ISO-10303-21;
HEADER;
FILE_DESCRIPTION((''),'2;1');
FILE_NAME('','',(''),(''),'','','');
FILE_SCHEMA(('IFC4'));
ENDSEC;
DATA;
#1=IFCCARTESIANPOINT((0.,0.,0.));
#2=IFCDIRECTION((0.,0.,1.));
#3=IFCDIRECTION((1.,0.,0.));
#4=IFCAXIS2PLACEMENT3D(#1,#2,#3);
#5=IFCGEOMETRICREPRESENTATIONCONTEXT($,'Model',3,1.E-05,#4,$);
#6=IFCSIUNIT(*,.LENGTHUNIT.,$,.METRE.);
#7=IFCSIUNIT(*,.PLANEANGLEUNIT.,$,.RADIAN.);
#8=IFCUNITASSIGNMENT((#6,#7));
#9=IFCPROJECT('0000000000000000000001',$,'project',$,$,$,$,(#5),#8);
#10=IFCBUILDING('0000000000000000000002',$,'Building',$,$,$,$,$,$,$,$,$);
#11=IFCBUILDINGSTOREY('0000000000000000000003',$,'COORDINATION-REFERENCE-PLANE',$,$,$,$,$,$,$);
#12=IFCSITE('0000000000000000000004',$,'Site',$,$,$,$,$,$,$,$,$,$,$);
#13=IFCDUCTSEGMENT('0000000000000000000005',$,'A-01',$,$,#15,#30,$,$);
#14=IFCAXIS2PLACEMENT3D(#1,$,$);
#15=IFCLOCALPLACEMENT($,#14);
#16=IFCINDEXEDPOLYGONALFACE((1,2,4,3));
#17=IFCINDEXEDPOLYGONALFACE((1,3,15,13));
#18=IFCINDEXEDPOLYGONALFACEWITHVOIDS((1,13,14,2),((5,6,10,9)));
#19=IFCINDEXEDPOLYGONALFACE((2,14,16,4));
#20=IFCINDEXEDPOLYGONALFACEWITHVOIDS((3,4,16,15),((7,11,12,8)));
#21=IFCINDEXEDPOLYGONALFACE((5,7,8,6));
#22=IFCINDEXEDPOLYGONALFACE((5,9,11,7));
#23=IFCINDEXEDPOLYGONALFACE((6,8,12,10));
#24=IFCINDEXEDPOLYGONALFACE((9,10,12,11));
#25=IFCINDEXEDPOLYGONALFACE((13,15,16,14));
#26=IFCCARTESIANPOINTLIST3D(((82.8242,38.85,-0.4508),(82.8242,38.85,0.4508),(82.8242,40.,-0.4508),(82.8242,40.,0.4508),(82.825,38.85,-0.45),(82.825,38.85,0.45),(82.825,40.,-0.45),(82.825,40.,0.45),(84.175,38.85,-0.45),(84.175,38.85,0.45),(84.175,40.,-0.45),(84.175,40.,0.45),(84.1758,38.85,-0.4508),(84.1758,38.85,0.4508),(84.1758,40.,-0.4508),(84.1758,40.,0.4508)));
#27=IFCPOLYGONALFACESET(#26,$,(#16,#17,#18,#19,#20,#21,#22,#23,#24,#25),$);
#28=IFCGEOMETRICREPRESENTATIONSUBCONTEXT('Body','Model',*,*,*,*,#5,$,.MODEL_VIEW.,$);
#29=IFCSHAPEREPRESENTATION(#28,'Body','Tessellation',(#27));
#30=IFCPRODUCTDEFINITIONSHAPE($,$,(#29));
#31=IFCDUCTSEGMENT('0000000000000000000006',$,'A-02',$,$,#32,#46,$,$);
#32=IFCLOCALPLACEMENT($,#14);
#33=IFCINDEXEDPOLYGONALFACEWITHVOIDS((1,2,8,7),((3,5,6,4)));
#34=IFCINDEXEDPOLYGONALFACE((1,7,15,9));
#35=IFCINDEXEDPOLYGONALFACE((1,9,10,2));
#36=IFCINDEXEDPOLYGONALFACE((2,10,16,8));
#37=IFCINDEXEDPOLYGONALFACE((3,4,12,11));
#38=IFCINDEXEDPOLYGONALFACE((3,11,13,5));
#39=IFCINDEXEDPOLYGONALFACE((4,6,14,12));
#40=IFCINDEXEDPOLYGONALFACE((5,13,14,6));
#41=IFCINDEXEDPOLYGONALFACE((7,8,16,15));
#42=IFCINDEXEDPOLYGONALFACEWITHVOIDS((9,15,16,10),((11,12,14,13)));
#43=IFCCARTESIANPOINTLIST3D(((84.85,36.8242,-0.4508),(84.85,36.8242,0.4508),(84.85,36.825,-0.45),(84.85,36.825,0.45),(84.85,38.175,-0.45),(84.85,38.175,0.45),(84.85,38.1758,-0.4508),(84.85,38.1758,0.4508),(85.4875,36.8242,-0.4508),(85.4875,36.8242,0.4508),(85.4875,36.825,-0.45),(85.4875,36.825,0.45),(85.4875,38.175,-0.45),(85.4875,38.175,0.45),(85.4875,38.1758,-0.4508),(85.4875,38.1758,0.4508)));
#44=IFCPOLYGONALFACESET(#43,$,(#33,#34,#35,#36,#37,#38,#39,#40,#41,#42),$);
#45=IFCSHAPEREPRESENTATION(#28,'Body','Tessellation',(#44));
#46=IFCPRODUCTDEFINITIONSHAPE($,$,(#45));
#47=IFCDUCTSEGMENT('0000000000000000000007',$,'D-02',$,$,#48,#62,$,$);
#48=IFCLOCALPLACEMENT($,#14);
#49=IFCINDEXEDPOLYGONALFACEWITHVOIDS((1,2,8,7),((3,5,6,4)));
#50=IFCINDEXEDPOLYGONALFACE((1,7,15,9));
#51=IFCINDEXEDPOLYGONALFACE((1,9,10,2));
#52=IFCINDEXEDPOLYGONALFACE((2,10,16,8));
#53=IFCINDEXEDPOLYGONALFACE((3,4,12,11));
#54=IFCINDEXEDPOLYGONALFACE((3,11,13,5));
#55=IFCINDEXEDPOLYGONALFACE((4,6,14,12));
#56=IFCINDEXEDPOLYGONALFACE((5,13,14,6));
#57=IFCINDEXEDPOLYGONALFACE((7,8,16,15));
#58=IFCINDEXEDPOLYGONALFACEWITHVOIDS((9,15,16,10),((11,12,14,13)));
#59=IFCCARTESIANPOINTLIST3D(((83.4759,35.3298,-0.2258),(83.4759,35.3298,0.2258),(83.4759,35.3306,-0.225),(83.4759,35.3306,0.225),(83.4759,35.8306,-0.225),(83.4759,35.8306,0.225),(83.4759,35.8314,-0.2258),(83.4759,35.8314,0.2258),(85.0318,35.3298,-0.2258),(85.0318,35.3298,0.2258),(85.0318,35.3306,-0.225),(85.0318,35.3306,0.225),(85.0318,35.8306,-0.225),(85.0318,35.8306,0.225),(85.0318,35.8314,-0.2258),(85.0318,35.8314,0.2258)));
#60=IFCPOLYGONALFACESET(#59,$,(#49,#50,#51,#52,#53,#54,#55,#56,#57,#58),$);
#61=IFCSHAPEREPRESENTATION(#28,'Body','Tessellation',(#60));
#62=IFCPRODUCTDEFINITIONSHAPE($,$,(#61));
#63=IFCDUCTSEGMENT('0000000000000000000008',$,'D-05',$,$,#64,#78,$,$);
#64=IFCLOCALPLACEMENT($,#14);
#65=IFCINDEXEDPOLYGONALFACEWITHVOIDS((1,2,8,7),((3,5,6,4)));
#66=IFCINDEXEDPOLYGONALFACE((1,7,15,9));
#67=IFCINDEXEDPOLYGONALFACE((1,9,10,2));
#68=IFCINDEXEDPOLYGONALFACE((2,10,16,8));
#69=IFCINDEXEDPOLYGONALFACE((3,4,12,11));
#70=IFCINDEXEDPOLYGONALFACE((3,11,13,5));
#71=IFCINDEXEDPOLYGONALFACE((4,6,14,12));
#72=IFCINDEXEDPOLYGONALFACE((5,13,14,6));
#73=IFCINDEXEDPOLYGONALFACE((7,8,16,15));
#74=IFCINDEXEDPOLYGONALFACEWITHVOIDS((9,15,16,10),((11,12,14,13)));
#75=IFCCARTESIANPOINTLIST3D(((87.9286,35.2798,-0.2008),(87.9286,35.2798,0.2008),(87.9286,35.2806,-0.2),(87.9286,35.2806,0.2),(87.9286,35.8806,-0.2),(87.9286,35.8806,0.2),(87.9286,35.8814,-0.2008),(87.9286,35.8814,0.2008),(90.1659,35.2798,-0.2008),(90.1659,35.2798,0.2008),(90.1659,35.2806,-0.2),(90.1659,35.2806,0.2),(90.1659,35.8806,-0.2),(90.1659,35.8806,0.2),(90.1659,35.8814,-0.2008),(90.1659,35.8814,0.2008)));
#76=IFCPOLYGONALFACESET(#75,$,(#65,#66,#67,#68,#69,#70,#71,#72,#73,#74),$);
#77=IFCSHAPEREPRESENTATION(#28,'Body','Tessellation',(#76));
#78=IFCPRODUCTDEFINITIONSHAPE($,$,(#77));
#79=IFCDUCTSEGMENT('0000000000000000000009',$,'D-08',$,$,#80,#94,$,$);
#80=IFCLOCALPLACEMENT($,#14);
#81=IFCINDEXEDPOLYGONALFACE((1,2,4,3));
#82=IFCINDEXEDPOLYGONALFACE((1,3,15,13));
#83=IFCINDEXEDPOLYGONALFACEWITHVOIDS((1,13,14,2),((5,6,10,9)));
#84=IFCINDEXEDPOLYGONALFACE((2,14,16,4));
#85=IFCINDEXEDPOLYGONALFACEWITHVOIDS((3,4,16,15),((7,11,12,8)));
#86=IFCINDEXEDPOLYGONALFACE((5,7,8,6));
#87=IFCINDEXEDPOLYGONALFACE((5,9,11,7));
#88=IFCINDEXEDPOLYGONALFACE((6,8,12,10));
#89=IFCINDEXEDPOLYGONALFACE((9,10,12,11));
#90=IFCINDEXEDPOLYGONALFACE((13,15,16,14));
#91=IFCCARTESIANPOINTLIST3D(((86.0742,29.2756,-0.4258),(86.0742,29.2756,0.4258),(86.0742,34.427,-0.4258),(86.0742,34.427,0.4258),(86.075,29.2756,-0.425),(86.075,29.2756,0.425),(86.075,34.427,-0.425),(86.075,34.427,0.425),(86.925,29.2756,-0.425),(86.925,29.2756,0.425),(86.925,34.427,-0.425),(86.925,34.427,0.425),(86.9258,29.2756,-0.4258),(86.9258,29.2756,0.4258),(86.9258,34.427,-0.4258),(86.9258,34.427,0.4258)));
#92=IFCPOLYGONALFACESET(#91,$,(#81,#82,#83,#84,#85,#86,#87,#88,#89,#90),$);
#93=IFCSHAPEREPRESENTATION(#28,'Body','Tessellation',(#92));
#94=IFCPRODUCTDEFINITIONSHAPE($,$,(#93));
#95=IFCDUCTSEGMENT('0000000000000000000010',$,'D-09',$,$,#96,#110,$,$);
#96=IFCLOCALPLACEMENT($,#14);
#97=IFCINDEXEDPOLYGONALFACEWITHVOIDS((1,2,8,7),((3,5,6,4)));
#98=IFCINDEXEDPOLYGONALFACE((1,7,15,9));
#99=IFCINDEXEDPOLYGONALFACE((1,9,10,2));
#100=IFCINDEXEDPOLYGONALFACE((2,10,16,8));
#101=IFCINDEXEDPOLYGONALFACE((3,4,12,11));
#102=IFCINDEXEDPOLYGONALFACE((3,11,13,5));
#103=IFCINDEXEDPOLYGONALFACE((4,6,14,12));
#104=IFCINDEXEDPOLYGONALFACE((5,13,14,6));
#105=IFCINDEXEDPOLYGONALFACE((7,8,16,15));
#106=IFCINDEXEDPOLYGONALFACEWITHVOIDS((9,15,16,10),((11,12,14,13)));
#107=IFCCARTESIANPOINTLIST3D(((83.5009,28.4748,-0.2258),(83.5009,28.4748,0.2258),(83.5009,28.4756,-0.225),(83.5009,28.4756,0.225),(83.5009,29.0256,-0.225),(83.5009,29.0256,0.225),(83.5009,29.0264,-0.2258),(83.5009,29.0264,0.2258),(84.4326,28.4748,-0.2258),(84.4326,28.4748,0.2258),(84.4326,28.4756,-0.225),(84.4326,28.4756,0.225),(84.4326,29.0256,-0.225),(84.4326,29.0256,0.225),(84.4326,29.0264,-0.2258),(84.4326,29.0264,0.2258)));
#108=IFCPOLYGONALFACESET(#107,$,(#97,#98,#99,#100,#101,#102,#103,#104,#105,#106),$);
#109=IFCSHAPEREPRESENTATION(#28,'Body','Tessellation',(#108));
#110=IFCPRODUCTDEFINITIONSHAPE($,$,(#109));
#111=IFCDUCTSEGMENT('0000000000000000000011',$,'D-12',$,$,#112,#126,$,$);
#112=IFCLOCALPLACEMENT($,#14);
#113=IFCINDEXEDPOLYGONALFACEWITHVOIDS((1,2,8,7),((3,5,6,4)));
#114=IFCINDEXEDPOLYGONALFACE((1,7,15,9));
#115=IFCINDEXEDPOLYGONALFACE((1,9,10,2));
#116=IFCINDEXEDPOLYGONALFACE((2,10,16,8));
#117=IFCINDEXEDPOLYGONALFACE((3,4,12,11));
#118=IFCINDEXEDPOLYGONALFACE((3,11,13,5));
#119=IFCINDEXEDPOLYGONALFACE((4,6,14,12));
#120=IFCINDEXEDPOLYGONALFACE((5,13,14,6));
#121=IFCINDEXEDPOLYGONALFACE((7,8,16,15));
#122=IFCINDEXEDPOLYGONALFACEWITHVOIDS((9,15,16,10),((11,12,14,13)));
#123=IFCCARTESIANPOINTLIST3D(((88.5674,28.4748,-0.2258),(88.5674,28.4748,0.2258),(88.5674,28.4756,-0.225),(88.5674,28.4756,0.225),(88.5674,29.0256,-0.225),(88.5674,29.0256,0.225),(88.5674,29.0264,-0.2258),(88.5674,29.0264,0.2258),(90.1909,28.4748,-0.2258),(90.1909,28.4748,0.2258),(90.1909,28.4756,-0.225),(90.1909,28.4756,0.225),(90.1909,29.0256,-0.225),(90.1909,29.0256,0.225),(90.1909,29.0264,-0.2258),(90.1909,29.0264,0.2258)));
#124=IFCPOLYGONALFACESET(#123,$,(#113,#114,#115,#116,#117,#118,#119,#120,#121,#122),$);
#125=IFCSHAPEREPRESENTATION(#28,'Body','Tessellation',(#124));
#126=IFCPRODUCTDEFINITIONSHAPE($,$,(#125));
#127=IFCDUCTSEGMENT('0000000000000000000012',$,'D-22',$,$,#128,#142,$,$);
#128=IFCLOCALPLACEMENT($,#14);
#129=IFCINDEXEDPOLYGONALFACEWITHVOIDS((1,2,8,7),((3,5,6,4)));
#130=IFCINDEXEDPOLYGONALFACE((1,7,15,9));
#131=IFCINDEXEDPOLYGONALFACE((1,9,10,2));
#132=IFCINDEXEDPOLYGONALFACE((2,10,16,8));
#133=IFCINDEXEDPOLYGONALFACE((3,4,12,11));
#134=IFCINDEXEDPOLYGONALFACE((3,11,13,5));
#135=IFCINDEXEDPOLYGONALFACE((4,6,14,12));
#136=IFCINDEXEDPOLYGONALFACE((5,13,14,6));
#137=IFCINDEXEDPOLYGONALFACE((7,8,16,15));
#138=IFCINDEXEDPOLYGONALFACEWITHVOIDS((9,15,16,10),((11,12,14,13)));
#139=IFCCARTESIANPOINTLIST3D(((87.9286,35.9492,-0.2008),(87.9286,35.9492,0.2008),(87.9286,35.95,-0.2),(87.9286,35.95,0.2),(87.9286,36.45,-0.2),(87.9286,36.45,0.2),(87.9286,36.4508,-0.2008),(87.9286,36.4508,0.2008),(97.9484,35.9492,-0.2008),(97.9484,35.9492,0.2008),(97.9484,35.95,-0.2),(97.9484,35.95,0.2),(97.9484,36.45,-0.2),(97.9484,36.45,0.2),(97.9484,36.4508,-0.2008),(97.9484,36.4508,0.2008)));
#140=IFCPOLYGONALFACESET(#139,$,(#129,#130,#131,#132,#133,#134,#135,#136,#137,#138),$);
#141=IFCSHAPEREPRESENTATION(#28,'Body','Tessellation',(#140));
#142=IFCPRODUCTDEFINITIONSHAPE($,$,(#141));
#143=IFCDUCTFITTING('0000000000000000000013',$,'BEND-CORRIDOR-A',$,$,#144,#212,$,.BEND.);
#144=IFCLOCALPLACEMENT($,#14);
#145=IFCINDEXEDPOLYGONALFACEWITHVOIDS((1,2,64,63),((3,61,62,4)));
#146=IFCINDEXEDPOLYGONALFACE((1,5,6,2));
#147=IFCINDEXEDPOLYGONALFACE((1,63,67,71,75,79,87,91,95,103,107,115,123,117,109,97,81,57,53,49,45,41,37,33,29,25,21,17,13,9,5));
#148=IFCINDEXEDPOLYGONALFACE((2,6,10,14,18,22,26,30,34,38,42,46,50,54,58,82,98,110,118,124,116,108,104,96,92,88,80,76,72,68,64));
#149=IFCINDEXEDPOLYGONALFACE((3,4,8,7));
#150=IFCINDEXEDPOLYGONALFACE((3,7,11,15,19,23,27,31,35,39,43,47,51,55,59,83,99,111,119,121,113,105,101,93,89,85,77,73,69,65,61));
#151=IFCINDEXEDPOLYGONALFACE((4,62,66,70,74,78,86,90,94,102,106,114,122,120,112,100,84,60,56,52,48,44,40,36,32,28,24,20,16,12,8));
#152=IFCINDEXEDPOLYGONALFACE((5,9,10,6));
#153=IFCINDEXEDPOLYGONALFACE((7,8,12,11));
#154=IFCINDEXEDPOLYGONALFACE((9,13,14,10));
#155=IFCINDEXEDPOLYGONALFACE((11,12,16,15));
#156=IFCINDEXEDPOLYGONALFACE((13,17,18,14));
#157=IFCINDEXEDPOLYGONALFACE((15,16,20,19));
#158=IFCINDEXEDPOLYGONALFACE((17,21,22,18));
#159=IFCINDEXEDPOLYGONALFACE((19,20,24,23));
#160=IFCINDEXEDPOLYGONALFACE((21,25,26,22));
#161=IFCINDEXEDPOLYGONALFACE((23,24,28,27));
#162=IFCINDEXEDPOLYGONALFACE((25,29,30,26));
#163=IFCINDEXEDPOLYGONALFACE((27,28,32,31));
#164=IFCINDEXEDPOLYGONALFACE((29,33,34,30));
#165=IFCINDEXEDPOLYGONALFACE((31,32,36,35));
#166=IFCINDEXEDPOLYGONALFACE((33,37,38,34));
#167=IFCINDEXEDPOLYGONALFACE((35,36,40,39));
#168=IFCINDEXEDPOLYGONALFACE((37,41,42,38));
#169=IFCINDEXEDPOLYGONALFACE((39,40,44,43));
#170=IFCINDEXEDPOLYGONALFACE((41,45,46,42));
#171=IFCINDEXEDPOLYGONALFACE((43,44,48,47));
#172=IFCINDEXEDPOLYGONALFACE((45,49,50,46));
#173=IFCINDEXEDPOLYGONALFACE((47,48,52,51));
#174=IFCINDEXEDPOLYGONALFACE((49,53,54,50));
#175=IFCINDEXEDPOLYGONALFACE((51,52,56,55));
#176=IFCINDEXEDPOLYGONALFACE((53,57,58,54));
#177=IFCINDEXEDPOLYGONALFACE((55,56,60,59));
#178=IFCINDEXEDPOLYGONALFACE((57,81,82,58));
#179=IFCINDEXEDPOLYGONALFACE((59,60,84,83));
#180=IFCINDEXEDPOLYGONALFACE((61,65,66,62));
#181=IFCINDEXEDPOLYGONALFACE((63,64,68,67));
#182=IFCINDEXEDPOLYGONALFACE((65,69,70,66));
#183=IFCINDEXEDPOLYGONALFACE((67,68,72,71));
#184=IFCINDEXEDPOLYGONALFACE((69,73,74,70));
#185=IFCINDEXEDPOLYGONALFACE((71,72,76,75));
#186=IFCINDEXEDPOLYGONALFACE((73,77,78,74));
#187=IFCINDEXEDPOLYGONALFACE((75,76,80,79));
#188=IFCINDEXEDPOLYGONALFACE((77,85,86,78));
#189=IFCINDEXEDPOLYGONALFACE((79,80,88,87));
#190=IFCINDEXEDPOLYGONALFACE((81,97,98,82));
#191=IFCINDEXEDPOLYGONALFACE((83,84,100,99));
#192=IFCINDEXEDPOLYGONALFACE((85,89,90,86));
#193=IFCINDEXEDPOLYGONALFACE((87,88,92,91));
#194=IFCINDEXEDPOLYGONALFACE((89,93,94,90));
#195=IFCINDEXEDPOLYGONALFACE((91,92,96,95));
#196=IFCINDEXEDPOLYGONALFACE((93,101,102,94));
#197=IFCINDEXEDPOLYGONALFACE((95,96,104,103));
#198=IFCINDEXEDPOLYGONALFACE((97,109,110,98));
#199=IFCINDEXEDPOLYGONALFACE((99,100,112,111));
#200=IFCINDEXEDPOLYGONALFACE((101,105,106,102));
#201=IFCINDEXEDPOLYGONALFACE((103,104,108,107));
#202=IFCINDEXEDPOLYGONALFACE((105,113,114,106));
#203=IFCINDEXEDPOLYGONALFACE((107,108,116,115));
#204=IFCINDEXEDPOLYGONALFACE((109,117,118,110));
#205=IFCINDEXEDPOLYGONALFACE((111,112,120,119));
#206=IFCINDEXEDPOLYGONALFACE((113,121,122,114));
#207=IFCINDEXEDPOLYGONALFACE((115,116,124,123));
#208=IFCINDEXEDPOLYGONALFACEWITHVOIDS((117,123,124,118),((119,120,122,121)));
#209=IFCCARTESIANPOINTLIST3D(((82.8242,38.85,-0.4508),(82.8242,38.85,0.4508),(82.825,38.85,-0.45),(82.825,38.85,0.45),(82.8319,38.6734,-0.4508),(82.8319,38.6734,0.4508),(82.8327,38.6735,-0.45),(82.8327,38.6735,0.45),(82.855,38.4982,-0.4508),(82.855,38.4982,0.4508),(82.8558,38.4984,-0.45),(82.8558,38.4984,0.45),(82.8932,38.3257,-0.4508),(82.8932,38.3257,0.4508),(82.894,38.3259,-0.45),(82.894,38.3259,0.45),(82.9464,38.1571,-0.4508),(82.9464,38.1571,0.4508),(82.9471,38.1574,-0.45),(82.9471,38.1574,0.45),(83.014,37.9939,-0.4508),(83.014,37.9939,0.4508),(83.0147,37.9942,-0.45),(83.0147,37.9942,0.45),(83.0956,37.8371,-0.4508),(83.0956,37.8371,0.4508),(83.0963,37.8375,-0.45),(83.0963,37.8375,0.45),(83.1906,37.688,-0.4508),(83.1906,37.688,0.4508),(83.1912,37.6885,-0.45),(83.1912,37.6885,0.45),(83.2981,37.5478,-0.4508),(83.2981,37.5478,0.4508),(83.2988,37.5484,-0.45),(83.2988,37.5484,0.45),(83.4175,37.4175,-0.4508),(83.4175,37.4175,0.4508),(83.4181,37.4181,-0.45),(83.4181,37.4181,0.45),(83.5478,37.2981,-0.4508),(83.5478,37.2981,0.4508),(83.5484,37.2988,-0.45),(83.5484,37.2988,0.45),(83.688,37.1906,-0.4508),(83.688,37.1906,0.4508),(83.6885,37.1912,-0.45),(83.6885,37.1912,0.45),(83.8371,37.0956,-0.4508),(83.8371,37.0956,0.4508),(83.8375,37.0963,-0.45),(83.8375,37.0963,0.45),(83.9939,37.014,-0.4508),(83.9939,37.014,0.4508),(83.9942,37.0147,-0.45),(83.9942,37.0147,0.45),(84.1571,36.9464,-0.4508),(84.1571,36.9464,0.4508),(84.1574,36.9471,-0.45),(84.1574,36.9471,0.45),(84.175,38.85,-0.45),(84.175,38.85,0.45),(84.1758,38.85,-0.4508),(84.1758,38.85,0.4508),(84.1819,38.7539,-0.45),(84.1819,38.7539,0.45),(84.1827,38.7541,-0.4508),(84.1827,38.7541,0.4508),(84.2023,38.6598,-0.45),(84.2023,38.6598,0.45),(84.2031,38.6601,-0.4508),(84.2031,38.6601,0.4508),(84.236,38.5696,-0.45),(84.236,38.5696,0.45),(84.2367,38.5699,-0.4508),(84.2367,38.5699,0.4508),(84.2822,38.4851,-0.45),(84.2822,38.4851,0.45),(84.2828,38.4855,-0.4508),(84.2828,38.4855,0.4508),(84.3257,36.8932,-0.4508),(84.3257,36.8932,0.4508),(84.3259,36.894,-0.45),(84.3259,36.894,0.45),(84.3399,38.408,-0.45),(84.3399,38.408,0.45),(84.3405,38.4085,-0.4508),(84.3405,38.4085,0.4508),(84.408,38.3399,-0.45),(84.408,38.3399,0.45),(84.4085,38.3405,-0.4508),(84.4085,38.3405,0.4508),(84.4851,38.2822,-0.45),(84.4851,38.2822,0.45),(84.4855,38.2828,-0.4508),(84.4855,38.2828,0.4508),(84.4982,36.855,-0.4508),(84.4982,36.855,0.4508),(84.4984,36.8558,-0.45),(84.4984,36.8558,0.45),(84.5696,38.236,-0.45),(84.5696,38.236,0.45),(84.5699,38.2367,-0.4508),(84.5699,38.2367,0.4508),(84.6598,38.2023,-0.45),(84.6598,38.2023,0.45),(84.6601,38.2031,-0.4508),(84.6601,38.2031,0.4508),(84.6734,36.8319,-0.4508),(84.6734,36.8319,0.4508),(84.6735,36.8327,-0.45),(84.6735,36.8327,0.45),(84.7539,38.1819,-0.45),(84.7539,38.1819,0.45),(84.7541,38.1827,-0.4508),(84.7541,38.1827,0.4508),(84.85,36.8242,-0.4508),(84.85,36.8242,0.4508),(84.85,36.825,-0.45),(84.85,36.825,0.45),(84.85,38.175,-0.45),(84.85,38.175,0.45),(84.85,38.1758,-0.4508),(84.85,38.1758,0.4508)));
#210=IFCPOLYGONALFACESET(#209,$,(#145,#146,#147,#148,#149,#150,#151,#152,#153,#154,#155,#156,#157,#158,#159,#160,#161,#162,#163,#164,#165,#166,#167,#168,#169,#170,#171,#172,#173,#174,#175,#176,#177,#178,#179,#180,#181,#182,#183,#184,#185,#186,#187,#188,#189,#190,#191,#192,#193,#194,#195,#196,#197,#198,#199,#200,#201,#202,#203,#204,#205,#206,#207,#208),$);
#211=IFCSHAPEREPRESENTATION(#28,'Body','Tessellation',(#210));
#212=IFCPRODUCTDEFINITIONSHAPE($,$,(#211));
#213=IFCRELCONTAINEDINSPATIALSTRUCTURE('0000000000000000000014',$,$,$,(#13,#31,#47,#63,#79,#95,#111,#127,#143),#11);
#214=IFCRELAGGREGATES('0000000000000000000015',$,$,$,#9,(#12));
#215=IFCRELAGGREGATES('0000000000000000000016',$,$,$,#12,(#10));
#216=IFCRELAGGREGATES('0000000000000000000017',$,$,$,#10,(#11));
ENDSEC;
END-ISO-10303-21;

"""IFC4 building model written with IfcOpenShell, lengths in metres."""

from ifc_helpers import new_model, entity, si_unit, frame, origin, origin_with_axes, place, context, subcontext, project, spatial, hollow_rectangle, extrude, element, save


model = new_model("IFC4")

# Units and contexts
model_context = context("Model", 3, precision=1e-05, world=origin_with_axes())
body_context = subcontext(model_context, "Body", "Model", "MODEL_VIEW")
ifc_project = project(units=[si_unit("LENGTHUNIT", "METRE"), si_unit("PLANEANGLEUNIT", "RADIAN")], contexts=[model_context])

# Site, building, storey
site = spatial("IfcSite", under=ifc_project, Name="Site")
building = spatial("IfcBuilding", under=site, Name="Building")
storey = spatial("IfcBuildingStorey", under=building, Name="COORDINATION-REFERENCE-PLANE")

# Duct segments
duct_segment_1_placement = place(None, frame((83.5, 38.85, 0.0), z_axis=(0.0, 1.0, 0.0), x_axis=(1.0, 0.0, 0.0)))
element("IfcDuctSegment", 1, at=duct_segment_1_placement, inside=storey, Name="A-01", context=body_context, shape_type="SweptSolid", body=[
    extrude(hollow_rectangle(XDim=1.3516, YDim=0.9016, WallThickness=0.0008), origin(), (0.0, 0.0, 1.0), 1.15),
])
duct_segment_2_placement = place(None, frame((84.85, 37.5, 0.0), z_axis=(1.0, 0.0, 0.0), x_axis=(0.0, 1.0, 0.0)))
element("IfcDuctSegment", 2, at=duct_segment_2_placement, inside=storey, Name="A-02", context=body_context, shape_type="SweptSolid", body=[
    extrude(hollow_rectangle(XDim=1.3516, YDim=0.9016, WallThickness=0.0008), origin(), (0.0, 0.0, 1.0), 0.6375),
])
duct_segment_3_placement = place(None, frame((83.4759, 35.5806, 0.0), z_axis=(1.0, 0.0, 0.0), x_axis=(0.0, 1.0, 0.0)))
element("IfcDuctSegment", 3, at=duct_segment_3_placement, inside=storey, Name="D-02", context=body_context, shape_type="SweptSolid", body=[
    extrude(hollow_rectangle(XDim=0.5016, YDim=0.4516, WallThickness=0.0008), origin(), (0.0, 0.0, 1.0), 1.5559),
])
duct_segment_4_placement = place(None, frame((87.9286, 35.5806, 0.0), z_axis=(1.0, 0.0, 0.0), x_axis=(0.0, 1.0, 0.0)))
element("IfcDuctSegment", 4, at=duct_segment_4_placement, inside=storey, Name="D-05", context=body_context, shape_type="SweptSolid", body=[
    extrude(hollow_rectangle(XDim=0.6016, YDim=0.4016, WallThickness=0.0008), origin(), (0.0, 0.0, 1.0), 2.2374),
])
duct_segment_5_placement = place(None, frame((86.5, 29.2756, 0.0), z_axis=(0.0, 1.0, 0.0), x_axis=(1.0, 0.0, 0.0)))
element("IfcDuctSegment", 5, at=duct_segment_5_placement, inside=storey, Name="D-08", context=body_context, shape_type="SweptSolid", body=[
    extrude(hollow_rectangle(XDim=0.8516, YDim=0.8516, WallThickness=0.0008), origin(), (0.0, 0.0, 1.0), 5.1514),
])
duct_segment_6_placement = place(None, frame((83.5009, 28.7506, 0.0), z_axis=(1.0, 0.0, 0.0), x_axis=(0.0, 1.0, 0.0)))
element("IfcDuctSegment", 6, at=duct_segment_6_placement, inside=storey, Name="D-09", context=body_context, shape_type="SweptSolid", body=[
    extrude(hollow_rectangle(XDim=0.5516, YDim=0.4516, WallThickness=0.0008), origin(), (0.0, 0.0, 1.0), 0.9316),
])
duct_segment_7_placement = place(None, frame((88.5674, 28.7506, 0.0), z_axis=(1.0, 0.0, 0.0), x_axis=(0.0, 1.0, 0.0)))
element("IfcDuctSegment", 7, at=duct_segment_7_placement, inside=storey, Name="D-12", context=body_context, shape_type="SweptSolid", body=[
    extrude(hollow_rectangle(XDim=0.5516, YDim=0.4516, WallThickness=0.0008), origin(), (0.0, 0.0, 1.0), 1.6235),
])
duct_segment_8_placement = place(None, frame((87.9286, 36.2, 0.0), z_axis=(1.0, 0.0, 0.0), x_axis=(0.0, 1.0, 0.0)))
element("IfcDuctSegment", 8, at=duct_segment_8_placement, inside=storey, Name="D-22", context=body_context, shape_type="SweptSolid", body=[
    extrude(hollow_rectangle(XDim=0.5016, YDim=0.4016, WallThickness=0.0008), origin(), (0.0, 0.0, 1.0), 10.0199),
])

# Duct fitting
duct_fitting_1_placement = place(None, frame((84.85, 38.85, 0.0), z_axis=(0.0, 0.0, 1.0), x_axis=(-1.0, 0.0, 0.0)))
cartesian_point_1 = entity("IfcCartesianPoint", [0.0, 0.0, 0.0])
element("IfcDuctFitting", 9, at=duct_fitting_1_placement, inside=storey, Name="BEND-CORRIDOR-A", PredefinedType="BEND", context=body_context, shape_type="SweptSolid", body=[
    entity("IfcRevolvedAreaSolid", entity("IfcRectangleHollowProfileDef", "AREA", None, entity("IfcAxis2Placement2D", entity("IfcCartesianPoint", [1.35, 0.0])), 1.3516, 0.9016, 0.0008), entity("IfcAxis2Placement3D", cartesian_point_1, entity("IfcDirection", [0.0, -1.0, 0.0]), entity("IfcDirection", [1.0, 0.0, 0.0])), entity("IfcAxis1Placement", cartesian_point_1, entity("IfcDirection", [0.0, 1.0, 0.0])), 1.570796),
])

save(model, "model.ifc")
